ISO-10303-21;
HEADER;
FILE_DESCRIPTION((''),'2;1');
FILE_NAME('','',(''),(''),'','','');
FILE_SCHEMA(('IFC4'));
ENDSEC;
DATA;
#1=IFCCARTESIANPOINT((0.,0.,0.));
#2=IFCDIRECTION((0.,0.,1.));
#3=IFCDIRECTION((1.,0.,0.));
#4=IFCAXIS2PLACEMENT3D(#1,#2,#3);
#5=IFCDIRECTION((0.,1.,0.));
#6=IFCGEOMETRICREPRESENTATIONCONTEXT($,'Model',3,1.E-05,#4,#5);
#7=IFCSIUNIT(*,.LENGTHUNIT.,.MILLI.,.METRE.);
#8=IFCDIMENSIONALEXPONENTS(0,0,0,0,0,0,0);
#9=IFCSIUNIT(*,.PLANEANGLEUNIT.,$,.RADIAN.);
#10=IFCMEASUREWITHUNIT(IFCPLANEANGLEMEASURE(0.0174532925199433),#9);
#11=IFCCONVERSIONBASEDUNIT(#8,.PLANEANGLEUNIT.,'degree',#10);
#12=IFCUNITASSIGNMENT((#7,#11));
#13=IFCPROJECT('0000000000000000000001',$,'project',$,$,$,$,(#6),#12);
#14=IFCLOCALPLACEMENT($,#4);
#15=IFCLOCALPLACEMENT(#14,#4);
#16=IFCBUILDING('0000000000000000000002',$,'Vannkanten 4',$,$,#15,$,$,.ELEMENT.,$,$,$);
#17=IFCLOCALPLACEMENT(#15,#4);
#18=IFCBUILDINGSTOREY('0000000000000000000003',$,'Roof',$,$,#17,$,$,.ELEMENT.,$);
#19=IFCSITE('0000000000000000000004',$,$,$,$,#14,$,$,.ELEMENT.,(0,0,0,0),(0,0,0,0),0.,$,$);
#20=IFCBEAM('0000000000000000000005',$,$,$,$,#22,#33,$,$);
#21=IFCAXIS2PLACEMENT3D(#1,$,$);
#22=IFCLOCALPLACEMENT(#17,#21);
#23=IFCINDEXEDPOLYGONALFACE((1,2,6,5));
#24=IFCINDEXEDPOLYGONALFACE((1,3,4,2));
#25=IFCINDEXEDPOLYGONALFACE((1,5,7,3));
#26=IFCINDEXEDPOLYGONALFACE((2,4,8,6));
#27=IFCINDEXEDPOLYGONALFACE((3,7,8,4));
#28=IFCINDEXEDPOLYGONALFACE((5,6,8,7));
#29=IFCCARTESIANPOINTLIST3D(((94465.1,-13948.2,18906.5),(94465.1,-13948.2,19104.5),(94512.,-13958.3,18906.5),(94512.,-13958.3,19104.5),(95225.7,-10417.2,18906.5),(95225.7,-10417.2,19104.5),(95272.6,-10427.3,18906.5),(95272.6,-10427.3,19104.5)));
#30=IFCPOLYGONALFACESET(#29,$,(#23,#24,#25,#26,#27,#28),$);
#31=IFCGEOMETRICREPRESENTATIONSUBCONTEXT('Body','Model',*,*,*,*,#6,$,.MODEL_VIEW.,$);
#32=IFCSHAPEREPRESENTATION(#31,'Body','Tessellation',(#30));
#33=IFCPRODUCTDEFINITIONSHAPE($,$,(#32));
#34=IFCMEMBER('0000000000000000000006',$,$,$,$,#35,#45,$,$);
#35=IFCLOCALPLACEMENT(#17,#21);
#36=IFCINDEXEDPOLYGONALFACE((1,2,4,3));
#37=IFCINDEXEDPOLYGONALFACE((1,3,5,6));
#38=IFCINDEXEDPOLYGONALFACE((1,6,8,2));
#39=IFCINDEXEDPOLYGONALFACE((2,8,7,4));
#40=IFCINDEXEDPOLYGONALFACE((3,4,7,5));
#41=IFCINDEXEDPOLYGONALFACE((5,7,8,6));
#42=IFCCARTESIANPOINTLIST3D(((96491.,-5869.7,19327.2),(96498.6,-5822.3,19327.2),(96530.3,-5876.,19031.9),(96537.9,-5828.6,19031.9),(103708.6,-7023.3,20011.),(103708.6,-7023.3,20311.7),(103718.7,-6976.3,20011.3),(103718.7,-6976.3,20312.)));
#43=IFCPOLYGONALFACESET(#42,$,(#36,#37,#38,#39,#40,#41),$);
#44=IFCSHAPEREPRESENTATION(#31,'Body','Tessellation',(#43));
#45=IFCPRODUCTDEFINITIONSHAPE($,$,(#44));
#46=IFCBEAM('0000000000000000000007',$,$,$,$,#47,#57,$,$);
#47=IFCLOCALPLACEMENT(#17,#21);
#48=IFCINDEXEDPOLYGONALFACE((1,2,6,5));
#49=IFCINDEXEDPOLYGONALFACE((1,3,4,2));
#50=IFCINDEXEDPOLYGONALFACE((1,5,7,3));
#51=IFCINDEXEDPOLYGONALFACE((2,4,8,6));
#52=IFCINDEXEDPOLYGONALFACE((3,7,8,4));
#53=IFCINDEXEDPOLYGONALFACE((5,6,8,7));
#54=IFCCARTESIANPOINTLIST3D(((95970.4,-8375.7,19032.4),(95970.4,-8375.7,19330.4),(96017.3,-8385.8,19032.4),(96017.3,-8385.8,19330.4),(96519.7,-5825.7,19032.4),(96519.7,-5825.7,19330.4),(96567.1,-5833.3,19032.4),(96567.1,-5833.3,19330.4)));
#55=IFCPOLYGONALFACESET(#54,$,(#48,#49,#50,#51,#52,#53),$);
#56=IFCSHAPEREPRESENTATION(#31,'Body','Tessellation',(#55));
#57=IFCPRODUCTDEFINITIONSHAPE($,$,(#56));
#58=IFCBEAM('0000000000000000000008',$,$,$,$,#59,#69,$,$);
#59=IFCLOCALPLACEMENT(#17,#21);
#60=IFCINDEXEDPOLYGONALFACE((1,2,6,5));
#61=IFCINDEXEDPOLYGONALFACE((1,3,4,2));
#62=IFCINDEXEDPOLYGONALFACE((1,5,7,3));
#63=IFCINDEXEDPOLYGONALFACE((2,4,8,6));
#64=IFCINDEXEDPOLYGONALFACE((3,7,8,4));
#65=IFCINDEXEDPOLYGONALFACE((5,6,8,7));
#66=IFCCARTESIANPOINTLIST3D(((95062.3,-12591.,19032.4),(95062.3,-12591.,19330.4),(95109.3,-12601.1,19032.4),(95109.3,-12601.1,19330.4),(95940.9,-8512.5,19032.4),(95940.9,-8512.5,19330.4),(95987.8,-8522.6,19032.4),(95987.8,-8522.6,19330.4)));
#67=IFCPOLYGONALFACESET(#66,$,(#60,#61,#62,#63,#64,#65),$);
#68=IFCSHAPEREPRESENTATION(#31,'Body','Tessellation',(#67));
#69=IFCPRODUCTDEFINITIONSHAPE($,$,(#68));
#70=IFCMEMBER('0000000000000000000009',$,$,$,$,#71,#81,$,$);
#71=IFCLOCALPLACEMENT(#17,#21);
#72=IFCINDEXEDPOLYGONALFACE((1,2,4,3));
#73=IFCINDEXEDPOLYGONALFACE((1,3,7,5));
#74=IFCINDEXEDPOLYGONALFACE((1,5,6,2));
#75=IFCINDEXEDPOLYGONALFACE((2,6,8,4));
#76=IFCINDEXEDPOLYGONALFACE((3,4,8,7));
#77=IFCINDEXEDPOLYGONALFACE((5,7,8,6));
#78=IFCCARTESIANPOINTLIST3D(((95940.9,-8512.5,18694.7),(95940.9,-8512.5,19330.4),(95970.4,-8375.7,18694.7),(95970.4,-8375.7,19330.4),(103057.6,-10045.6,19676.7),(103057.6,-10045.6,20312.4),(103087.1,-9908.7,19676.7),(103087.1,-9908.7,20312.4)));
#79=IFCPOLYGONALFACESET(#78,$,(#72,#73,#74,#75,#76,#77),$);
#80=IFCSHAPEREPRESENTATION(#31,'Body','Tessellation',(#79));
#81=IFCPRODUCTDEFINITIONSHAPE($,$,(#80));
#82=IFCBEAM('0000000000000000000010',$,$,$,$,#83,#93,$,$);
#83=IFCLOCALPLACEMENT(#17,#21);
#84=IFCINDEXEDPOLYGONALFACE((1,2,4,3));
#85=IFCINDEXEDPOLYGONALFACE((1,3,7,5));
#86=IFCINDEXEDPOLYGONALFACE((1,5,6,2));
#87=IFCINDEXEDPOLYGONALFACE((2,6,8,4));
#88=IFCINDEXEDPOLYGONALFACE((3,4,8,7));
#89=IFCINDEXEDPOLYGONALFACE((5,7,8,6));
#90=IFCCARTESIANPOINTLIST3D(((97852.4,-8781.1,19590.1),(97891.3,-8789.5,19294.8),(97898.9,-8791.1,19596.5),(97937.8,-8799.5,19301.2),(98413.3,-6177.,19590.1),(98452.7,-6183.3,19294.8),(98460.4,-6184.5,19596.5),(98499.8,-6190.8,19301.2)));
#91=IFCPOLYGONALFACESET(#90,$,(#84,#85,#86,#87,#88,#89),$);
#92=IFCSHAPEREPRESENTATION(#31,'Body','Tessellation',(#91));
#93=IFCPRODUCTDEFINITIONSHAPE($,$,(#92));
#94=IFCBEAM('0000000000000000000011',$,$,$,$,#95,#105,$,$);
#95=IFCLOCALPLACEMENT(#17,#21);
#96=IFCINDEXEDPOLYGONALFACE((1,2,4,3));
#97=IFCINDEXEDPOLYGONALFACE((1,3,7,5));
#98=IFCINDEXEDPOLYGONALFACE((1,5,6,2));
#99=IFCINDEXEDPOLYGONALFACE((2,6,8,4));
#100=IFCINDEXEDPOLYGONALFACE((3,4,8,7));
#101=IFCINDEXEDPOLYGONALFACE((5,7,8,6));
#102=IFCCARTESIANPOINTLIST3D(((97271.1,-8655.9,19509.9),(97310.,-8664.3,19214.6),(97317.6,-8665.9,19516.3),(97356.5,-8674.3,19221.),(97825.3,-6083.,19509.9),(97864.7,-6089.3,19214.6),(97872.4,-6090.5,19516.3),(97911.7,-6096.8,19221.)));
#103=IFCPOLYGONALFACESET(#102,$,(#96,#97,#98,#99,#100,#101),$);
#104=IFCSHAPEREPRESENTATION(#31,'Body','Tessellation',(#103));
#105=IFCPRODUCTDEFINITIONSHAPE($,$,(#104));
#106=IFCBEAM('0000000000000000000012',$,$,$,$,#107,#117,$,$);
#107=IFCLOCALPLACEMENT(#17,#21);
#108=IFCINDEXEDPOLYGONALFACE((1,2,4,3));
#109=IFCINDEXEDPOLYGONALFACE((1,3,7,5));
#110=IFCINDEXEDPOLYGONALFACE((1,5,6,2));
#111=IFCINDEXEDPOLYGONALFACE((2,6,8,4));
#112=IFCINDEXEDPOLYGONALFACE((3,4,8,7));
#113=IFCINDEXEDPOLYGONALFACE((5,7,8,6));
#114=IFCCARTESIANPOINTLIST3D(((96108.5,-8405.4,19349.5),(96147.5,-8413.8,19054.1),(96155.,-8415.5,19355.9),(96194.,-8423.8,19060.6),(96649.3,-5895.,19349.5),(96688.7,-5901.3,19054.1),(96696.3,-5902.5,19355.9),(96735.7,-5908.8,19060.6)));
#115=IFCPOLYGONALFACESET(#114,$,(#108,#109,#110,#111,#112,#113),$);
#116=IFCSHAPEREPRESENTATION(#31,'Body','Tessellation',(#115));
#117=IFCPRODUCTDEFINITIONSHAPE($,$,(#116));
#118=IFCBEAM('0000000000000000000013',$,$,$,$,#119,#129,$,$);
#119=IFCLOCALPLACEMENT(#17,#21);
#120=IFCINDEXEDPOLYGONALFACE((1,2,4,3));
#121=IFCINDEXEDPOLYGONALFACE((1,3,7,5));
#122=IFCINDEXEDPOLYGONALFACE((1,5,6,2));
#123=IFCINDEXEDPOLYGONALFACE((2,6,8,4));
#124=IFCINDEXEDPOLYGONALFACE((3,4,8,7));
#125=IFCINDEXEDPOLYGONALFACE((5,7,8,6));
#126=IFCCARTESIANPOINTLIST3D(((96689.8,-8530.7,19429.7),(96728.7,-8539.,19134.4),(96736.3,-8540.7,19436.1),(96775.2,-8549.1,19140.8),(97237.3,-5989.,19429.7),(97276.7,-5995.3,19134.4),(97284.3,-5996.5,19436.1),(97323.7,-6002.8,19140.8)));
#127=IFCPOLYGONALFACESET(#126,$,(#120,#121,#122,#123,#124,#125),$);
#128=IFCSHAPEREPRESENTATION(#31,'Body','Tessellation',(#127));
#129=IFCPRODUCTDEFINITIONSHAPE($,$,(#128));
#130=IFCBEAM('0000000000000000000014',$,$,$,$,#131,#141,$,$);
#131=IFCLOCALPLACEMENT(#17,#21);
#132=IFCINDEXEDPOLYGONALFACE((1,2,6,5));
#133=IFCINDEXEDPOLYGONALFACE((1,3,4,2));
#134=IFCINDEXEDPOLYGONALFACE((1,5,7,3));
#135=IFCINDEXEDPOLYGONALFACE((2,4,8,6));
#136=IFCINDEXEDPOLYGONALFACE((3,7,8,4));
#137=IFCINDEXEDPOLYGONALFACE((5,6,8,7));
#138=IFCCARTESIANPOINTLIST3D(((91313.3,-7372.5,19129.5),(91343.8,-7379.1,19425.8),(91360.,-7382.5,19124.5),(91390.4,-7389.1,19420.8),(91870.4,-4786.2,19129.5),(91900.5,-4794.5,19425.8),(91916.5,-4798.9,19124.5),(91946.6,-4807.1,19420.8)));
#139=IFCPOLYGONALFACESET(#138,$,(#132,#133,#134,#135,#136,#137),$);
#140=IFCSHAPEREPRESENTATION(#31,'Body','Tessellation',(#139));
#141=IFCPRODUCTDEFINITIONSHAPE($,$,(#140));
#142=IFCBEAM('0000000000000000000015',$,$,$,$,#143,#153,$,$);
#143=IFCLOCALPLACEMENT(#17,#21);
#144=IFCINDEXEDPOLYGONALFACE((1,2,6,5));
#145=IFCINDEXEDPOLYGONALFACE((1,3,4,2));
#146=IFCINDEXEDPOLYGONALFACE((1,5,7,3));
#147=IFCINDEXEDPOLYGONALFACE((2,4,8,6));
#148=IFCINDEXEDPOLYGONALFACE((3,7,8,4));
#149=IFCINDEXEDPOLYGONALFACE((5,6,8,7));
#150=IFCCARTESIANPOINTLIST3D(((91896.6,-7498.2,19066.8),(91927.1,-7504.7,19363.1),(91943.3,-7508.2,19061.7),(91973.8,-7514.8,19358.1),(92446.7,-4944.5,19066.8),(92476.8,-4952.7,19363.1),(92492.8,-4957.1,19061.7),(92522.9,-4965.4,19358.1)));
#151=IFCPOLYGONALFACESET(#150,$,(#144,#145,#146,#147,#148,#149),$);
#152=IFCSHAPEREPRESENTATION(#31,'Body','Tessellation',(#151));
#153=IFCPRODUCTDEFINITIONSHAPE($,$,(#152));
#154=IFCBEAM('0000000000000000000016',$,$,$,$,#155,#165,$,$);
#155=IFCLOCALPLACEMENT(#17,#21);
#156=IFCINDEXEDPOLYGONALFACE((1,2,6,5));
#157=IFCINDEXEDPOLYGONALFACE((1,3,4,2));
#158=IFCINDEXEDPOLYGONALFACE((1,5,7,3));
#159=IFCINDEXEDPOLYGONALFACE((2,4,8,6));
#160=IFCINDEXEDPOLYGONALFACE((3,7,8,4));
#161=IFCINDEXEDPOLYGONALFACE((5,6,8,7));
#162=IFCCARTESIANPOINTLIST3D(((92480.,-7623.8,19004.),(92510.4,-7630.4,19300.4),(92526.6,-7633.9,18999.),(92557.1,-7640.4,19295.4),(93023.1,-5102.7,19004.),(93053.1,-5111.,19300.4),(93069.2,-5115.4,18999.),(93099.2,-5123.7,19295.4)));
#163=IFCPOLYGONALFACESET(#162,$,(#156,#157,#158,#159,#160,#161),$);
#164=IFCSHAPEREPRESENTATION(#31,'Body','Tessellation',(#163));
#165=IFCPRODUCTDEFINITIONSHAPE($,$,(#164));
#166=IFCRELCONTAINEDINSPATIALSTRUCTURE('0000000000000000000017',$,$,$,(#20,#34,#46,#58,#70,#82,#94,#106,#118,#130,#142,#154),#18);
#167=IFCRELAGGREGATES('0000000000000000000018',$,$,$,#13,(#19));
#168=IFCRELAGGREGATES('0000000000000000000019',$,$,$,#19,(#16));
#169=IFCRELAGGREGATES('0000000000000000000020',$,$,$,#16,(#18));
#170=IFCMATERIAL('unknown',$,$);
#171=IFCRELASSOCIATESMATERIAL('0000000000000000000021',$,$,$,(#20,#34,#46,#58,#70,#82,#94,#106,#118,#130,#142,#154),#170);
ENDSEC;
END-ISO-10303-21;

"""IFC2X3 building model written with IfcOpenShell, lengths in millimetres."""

from ifc_helpers import new_model, entity, si_unit, converted_unit, direction, frame, origin_with_axes, place, context, subcontext, project, spatial, polyline, segment, composite_curve, outline, extrude, clip, halfspace, material, element, save


model = new_model("IFC2X3")

# Units and contexts
model_context = context("Model", 3, precision=1e-05, world=origin_with_axes(), true_north=direction((0.0, 1.0, 0.0)))
body_context = subcontext(model_context, "Body", "Model", "MODEL_VIEW")
ifc_project = project(units=[si_unit("LENGTHUNIT", "METRE", prefix="MILLI"), converted_unit("PLANEANGLEUNIT", "degree", entity("IfcPlaneAngleMeasure", 0.0174532925199433), si_unit("PLANEANGLEUNIT", "RADIAN"), dimensions=[0, 0, 0, 0, 0, 0, 0])], contexts=[model_context])

# Site, building, storey
site_placement = place(None, origin_with_axes())
site = spatial("IfcSite", under=ifc_project, at=site_placement, CompositionType="ELEMENT", RefLatitude=(0, 0, 0, 0), RefLongitude=(0, 0, 0, 0), RefElevation=0.0)
building_placement = place(site_placement, origin_with_axes())
building = spatial("IfcBuilding", under=site, at=building_placement, Name="Vannkanten 4", CompositionType="ELEMENT")
storey_placement = place(building_placement, origin_with_axes())
storey = spatial("IfcBuildingStorey", under=building, at=storey_placement, Name="Roof", CompositionType="ELEMENT")

# Beam
ifc_material = material(Name="unknown")
beam_1_placement = place(storey_placement, frame((95249.1, -10422.2, 19005.5), z_axis=(-0.210582, -0.977576, 0.0), x_axis=(0.977576, -0.210582, 0.0)))
element("IfcBeam", 1, at=beam_1_placement, inside=storey, material=ifc_material, context=body_context, shape_type="SweptSolid", body=[
    extrude(outline(composite_curve([segment(polyline([(-24.0, -99.0), (-24.0, 99.0), (24.0, 99.0), (24.0, -99.0), (-24.0, -99.0)]), True, "CONTINUOUS")], self_intersect=False)), frame((0.0, 0.0, 0.0), z_axis=(0.0, 0.0, 1.0), x_axis=(1.0, 0.0, 0.0)), (0.0, 0.0, 1.0), 3612.0),
])

# Member
member_1_placement = place(storey_placement, frame((96514.5, -5849.2, 19179.5), z_axis=(0.978629, -0.156419, 0.133486), x_axis=(0.157832, 0.987466, 0.0)))
element("IfcMember", 2, at=member_1_placement, inside=storey, material=ifc_material, context=body_context, shape_type="Clipping", body=[
    clip(extrude(outline(composite_curve([segment(polyline([(-24.0, -149.0), (-24.0, 149.0), (24.0, 149.0), (24.0, -149.0), (-24.0, -149.0)]), True, "CONTINUOUS")], self_intersect=False)), frame((0.0, 0.0, 0.0), z_axis=(0.0, 0.0, 1.0), x_axis=(1.0, 0.0, 0.0)), (0.0, 0.0, 1.0), 11066.6), halfspace(frame((-24.0, -149.0, 7335.0), z_axis=(0.053649, 0.133294, -0.989623), x_axis=(0.0, -0.991051, -0.133486)), True)),
])

# Beams
beam_2_placement = place(storey_placement, frame((96543.4, -5829.5, 19181.4), z_axis=(-0.210582, -0.977576, 0.0), x_axis=(0.977576, -0.210582, 0.0)))
element("IfcBeam", 3, at=beam_2_placement, inside=storey, material=ifc_material, context=body_context, shape_type="Clipping", body=[
    clip(extrude(outline(composite_curve([segment(polyline([(-24.0, -149.0), (-24.0, 149.0), (24.0, 149.0), (24.0, -149.0), (-24.0, -149.0)]), True, "CONTINUOUS")], self_intersect=False)), frame((0.0, 0.0, -1306.8), z_axis=(0.0, 0.0, 1.0), x_axis=(1.0, 0.0, 0.0)), (0.0, 0.0, 1.0), 3916.6), halfspace(frame((-24.0, 149.0, 1.3), z_axis=(0.053649, 0.0, 0.99856), x_axis=(0.99856, 0.0, -0.053649)), True)),
])
beam_3_placement = place(storey_placement, frame((95964.4, -8517.6, 19181.4), z_axis=(-0.210582, -0.977576, 0.0), x_axis=(0.977576, -0.210582, 0.0)))
element("IfcBeam", 4, at=beam_3_placement, inside=storey, material=ifc_material, context=body_context, shape_type="SweptSolid", body=[
    extrude(outline(composite_curve([segment(polyline([(-24.0, -149.0), (-24.0, 149.0), (24.0, 149.0), (24.0, -149.0), (-24.0, -149.0)]), True, "CONTINUOUS")], self_intersect=False)), frame((0.0, 0.0, 0.0), z_axis=(0.0, 0.0, 1.0), x_axis=(1.0, 0.0, 0.0)), (0.0, 0.0, 1.0), 4172.0),
])

# Member
member_2_placement = place(storey_placement, frame((95955.6, -8444.1, 19012.6), z_axis=(0.968803, -0.208692, 0.133675), x_axis=(0.210582, 0.977576, 0.0)))
element("IfcMember", 5, at=member_2_placement, inside=storey, material=ifc_material, context=body_context, shape_type="Clipping", body=[
    clip(clip(extrude(outline(composite_curve([segment(polyline([(-70.0, 315.0), (-70.0, -315.0), (70.0, -315.0), (70.0, 315.0), (-70.0, 315.0)]), True, "CONTINUOUS")], self_intersect=False)), frame((0.0, 0.0, -3757.9), z_axis=(0.0, 0.0, 1.0), x_axis=(1.0, 0.0, 0.0)), (0.0, 0.0, 1.0), 14861.8), halfspace(frame((-70.0, 315.0, 42.5), z_axis=(0.0, -0.133675, 0.991025), x_axis=(0.0, 0.991025, 0.133675)), True)), halfspace(frame((70.0, 315.0, 7388.4), z_axis=(0.0, 0.133675, -0.991025), x_axis=(0.0, -0.991025, -0.133675)), True)),
])

# Beams
beam_4_placement = place(storey_placement, frame((97895.1, -8790.3, 19445.6), z_axis=(0.210582, 0.977576, 0.0), x_axis=(-0.968803, 0.208692, -0.133675)))
element("IfcBeam", 6, at=beam_4_placement, inside=storey, material=ifc_material, context=body_context, shape_type="Clipping", body=[
    clip(extrude(outline(composite_curve([segment(polyline([(-24.0, -149.0), (-24.0, 149.0), (24.0, 149.0), (24.0, -149.0), (-24.0, -149.0)]), True, "CONTINUOUS")], self_intersect=False)), frame((0.0, 0.0, 0.0), z_axis=(0.0, 0.0, 1.0), x_axis=(1.0, 0.0, 0.0)), (0.0, 0.0, 1.0), 4002.8), halfspace(frame((-24.0, -149.0, 2668.5), z_axis=(-0.053168, -0.007172, -0.99856), x_axis=(-0.998586, 0.0, 0.053169)), True)),
])
beam_5_placement = place(storey_placement, frame((97313.8, -8665.1, 19365.4), z_axis=(0.210582, 0.977576, 0.0), x_axis=(-0.968803, 0.208692, -0.133675)))
element("IfcBeam", 7, at=beam_5_placement, inside=storey, material=ifc_material, context=body_context, shape_type="Clipping", body=[
    clip(extrude(outline(composite_curve([segment(polyline([(-24.0, -149.0), (-24.0, 149.0), (24.0, 149.0), (24.0, -149.0), (-24.0, -149.0)]), True, "CONTINUOUS")], self_intersect=False)), frame((0.0, 0.0, 0.0), z_axis=(0.0, 0.0, 1.0), x_axis=(1.0, 0.0, 0.0)), (0.0, 0.0, 1.0), 3954.9), halfspace(frame((-24.0, -149.0, 2636.6), z_axis=(-0.053168, -0.007172, -0.99856), x_axis=(-0.998586, 0.0, 0.053169)), True)),
])
beam_6_placement = place(storey_placement, frame((96151.2, -8414.6, 19205.0), z_axis=(0.210582, 0.977576, 0.0), x_axis=(-0.968803, 0.208692, -0.133675)))
element("IfcBeam", 8, at=beam_6_placement, inside=storey, material=ifc_material, context=body_context, shape_type="Clipping", body=[
    clip(extrude(outline(composite_curve([segment(polyline([(-24.0, -149.0), (-24.0, 149.0), (24.0, 149.0), (24.0, -149.0), (-24.0, -149.0)]), True, "CONTINUOUS")], self_intersect=False)), frame((0.0, 0.0, 0.0), z_axis=(0.0, 0.0, 1.0), x_axis=(1.0, 0.0, 0.0)), (0.0, 0.0, 1.0), 3859.1), halfspace(frame((-24.0, -149.0, 2572.7), z_axis=(-0.053168, -0.007172, -0.99856), x_axis=(-0.998586, 0.0, 0.053169)), True)),
])
beam_7_placement = place(storey_placement, frame((96732.5, -8539.9, 19285.2), z_axis=(0.210582, 0.977576, 0.0), x_axis=(-0.968803, 0.208692, -0.133675)))
element("IfcBeam", 9, at=beam_7_placement, inside=storey, material=ifc_material, context=body_context, shape_type="Clipping", body=[
    clip(extrude(outline(composite_curve([segment(polyline([(-24.0, -149.0), (-24.0, 149.0), (24.0, 149.0), (24.0, -149.0), (-24.0, -149.0)]), True, "CONTINUOUS")], self_intersect=False)), frame((0.0, 0.0, 0.0), z_axis=(0.0, 0.0, 1.0), x_axis=(1.0, 0.0, 0.0)), (0.0, 0.0, 1.0), 3907.0), halfspace(frame((-24.0, -149.0, 2604.7), z_axis=(-0.053168, -0.007172, -0.99856), x_axis=(-0.998586, 0.0, 0.053169)), True)),
])
beam_8_placement = place(storey_placement, frame((91351.9, -7380.8, 19275.1), z_axis=(0.210582, 0.977576, 0.0), x_axis=(-0.972221, 0.209428, 0.104528)))
element("IfcBeam", 10, at=beam_8_placement, inside=storey, material=ifc_material, context=body_context, shape_type="Clipping", body=[
    clip(extrude(outline(composite_curve([segment(polyline([(-24.0, -149.0), (-24.0, 149.0), (24.0, 149.0), (24.0, -149.0), (-24.0, -149.0)]), True, "CONTINUOUS")], self_intersect=False)), frame((0.0, 0.0, 0.0), z_axis=(0.0, 0.0, 1.0), x_axis=(1.0, 0.0, 0.0)), (0.0, 0.0, 1.0), 3968.4), halfspace(frame((-24.0, -149.0, 2642.9), z_axis=(0.055493, -0.005833, -0.998442), x_axis=(-0.998459, 0.0, -0.055494)), True)),
])
beam_9_placement = place(storey_placement, frame((91935.2, -7506.5, 19212.4), z_axis=(0.210582, 0.977576, 0.0), x_axis=(-0.972221, 0.209428, 0.104528)))
element("IfcBeam", 11, at=beam_9_placement, inside=storey, material=ifc_material, context=body_context, shape_type="Clipping", body=[
    clip(extrude(outline(composite_curve([segment(polyline([(-24.0, -149.0), (-24.0, 149.0), (24.0, 149.0), (24.0, -149.0), (-24.0, -149.0)]), True, "CONTINUOUS")], self_intersect=False)), frame((0.0, 0.0, 0.0), z_axis=(0.0, 0.0, 1.0), x_axis=(1.0, 0.0, 0.0)), (0.0, 0.0, 1.0), 3918.4), halfspace(frame((-24.0, -149.0, 2609.6), z_axis=(0.055493, -0.005833, -0.998442), x_axis=(-0.998459, 0.0, -0.055494)), True)),
])
beam_10_placement = place(storey_placement, frame((92518.5, -7632.1, 19149.7), z_axis=(0.210582, 0.977576, 0.0), x_axis=(-0.972221, 0.209428, 0.104528)))
element("IfcBeam", 12, at=beam_10_placement, inside=storey, material=ifc_material, context=body_context, shape_type="Clipping", body=[
    clip(extrude(outline(composite_curve([segment(polyline([(-24.0, -149.0), (-24.0, 149.0), (24.0, 149.0), (24.0, -149.0), (-24.0, -149.0)]), True, "CONTINUOUS")], self_intersect=False)), frame((0.0, 0.0, 0.0), z_axis=(0.0, 0.0, 1.0), x_axis=(1.0, 0.0, 0.0)), (0.0, 0.0, 1.0), 3868.4), halfspace(frame((-24.0, -149.0, 2576.2), z_axis=(0.055493, -0.005833, -0.998442), x_axis=(-0.998459, 0.0, -0.055494)), True)),
])

save(model, "model.ifc")
